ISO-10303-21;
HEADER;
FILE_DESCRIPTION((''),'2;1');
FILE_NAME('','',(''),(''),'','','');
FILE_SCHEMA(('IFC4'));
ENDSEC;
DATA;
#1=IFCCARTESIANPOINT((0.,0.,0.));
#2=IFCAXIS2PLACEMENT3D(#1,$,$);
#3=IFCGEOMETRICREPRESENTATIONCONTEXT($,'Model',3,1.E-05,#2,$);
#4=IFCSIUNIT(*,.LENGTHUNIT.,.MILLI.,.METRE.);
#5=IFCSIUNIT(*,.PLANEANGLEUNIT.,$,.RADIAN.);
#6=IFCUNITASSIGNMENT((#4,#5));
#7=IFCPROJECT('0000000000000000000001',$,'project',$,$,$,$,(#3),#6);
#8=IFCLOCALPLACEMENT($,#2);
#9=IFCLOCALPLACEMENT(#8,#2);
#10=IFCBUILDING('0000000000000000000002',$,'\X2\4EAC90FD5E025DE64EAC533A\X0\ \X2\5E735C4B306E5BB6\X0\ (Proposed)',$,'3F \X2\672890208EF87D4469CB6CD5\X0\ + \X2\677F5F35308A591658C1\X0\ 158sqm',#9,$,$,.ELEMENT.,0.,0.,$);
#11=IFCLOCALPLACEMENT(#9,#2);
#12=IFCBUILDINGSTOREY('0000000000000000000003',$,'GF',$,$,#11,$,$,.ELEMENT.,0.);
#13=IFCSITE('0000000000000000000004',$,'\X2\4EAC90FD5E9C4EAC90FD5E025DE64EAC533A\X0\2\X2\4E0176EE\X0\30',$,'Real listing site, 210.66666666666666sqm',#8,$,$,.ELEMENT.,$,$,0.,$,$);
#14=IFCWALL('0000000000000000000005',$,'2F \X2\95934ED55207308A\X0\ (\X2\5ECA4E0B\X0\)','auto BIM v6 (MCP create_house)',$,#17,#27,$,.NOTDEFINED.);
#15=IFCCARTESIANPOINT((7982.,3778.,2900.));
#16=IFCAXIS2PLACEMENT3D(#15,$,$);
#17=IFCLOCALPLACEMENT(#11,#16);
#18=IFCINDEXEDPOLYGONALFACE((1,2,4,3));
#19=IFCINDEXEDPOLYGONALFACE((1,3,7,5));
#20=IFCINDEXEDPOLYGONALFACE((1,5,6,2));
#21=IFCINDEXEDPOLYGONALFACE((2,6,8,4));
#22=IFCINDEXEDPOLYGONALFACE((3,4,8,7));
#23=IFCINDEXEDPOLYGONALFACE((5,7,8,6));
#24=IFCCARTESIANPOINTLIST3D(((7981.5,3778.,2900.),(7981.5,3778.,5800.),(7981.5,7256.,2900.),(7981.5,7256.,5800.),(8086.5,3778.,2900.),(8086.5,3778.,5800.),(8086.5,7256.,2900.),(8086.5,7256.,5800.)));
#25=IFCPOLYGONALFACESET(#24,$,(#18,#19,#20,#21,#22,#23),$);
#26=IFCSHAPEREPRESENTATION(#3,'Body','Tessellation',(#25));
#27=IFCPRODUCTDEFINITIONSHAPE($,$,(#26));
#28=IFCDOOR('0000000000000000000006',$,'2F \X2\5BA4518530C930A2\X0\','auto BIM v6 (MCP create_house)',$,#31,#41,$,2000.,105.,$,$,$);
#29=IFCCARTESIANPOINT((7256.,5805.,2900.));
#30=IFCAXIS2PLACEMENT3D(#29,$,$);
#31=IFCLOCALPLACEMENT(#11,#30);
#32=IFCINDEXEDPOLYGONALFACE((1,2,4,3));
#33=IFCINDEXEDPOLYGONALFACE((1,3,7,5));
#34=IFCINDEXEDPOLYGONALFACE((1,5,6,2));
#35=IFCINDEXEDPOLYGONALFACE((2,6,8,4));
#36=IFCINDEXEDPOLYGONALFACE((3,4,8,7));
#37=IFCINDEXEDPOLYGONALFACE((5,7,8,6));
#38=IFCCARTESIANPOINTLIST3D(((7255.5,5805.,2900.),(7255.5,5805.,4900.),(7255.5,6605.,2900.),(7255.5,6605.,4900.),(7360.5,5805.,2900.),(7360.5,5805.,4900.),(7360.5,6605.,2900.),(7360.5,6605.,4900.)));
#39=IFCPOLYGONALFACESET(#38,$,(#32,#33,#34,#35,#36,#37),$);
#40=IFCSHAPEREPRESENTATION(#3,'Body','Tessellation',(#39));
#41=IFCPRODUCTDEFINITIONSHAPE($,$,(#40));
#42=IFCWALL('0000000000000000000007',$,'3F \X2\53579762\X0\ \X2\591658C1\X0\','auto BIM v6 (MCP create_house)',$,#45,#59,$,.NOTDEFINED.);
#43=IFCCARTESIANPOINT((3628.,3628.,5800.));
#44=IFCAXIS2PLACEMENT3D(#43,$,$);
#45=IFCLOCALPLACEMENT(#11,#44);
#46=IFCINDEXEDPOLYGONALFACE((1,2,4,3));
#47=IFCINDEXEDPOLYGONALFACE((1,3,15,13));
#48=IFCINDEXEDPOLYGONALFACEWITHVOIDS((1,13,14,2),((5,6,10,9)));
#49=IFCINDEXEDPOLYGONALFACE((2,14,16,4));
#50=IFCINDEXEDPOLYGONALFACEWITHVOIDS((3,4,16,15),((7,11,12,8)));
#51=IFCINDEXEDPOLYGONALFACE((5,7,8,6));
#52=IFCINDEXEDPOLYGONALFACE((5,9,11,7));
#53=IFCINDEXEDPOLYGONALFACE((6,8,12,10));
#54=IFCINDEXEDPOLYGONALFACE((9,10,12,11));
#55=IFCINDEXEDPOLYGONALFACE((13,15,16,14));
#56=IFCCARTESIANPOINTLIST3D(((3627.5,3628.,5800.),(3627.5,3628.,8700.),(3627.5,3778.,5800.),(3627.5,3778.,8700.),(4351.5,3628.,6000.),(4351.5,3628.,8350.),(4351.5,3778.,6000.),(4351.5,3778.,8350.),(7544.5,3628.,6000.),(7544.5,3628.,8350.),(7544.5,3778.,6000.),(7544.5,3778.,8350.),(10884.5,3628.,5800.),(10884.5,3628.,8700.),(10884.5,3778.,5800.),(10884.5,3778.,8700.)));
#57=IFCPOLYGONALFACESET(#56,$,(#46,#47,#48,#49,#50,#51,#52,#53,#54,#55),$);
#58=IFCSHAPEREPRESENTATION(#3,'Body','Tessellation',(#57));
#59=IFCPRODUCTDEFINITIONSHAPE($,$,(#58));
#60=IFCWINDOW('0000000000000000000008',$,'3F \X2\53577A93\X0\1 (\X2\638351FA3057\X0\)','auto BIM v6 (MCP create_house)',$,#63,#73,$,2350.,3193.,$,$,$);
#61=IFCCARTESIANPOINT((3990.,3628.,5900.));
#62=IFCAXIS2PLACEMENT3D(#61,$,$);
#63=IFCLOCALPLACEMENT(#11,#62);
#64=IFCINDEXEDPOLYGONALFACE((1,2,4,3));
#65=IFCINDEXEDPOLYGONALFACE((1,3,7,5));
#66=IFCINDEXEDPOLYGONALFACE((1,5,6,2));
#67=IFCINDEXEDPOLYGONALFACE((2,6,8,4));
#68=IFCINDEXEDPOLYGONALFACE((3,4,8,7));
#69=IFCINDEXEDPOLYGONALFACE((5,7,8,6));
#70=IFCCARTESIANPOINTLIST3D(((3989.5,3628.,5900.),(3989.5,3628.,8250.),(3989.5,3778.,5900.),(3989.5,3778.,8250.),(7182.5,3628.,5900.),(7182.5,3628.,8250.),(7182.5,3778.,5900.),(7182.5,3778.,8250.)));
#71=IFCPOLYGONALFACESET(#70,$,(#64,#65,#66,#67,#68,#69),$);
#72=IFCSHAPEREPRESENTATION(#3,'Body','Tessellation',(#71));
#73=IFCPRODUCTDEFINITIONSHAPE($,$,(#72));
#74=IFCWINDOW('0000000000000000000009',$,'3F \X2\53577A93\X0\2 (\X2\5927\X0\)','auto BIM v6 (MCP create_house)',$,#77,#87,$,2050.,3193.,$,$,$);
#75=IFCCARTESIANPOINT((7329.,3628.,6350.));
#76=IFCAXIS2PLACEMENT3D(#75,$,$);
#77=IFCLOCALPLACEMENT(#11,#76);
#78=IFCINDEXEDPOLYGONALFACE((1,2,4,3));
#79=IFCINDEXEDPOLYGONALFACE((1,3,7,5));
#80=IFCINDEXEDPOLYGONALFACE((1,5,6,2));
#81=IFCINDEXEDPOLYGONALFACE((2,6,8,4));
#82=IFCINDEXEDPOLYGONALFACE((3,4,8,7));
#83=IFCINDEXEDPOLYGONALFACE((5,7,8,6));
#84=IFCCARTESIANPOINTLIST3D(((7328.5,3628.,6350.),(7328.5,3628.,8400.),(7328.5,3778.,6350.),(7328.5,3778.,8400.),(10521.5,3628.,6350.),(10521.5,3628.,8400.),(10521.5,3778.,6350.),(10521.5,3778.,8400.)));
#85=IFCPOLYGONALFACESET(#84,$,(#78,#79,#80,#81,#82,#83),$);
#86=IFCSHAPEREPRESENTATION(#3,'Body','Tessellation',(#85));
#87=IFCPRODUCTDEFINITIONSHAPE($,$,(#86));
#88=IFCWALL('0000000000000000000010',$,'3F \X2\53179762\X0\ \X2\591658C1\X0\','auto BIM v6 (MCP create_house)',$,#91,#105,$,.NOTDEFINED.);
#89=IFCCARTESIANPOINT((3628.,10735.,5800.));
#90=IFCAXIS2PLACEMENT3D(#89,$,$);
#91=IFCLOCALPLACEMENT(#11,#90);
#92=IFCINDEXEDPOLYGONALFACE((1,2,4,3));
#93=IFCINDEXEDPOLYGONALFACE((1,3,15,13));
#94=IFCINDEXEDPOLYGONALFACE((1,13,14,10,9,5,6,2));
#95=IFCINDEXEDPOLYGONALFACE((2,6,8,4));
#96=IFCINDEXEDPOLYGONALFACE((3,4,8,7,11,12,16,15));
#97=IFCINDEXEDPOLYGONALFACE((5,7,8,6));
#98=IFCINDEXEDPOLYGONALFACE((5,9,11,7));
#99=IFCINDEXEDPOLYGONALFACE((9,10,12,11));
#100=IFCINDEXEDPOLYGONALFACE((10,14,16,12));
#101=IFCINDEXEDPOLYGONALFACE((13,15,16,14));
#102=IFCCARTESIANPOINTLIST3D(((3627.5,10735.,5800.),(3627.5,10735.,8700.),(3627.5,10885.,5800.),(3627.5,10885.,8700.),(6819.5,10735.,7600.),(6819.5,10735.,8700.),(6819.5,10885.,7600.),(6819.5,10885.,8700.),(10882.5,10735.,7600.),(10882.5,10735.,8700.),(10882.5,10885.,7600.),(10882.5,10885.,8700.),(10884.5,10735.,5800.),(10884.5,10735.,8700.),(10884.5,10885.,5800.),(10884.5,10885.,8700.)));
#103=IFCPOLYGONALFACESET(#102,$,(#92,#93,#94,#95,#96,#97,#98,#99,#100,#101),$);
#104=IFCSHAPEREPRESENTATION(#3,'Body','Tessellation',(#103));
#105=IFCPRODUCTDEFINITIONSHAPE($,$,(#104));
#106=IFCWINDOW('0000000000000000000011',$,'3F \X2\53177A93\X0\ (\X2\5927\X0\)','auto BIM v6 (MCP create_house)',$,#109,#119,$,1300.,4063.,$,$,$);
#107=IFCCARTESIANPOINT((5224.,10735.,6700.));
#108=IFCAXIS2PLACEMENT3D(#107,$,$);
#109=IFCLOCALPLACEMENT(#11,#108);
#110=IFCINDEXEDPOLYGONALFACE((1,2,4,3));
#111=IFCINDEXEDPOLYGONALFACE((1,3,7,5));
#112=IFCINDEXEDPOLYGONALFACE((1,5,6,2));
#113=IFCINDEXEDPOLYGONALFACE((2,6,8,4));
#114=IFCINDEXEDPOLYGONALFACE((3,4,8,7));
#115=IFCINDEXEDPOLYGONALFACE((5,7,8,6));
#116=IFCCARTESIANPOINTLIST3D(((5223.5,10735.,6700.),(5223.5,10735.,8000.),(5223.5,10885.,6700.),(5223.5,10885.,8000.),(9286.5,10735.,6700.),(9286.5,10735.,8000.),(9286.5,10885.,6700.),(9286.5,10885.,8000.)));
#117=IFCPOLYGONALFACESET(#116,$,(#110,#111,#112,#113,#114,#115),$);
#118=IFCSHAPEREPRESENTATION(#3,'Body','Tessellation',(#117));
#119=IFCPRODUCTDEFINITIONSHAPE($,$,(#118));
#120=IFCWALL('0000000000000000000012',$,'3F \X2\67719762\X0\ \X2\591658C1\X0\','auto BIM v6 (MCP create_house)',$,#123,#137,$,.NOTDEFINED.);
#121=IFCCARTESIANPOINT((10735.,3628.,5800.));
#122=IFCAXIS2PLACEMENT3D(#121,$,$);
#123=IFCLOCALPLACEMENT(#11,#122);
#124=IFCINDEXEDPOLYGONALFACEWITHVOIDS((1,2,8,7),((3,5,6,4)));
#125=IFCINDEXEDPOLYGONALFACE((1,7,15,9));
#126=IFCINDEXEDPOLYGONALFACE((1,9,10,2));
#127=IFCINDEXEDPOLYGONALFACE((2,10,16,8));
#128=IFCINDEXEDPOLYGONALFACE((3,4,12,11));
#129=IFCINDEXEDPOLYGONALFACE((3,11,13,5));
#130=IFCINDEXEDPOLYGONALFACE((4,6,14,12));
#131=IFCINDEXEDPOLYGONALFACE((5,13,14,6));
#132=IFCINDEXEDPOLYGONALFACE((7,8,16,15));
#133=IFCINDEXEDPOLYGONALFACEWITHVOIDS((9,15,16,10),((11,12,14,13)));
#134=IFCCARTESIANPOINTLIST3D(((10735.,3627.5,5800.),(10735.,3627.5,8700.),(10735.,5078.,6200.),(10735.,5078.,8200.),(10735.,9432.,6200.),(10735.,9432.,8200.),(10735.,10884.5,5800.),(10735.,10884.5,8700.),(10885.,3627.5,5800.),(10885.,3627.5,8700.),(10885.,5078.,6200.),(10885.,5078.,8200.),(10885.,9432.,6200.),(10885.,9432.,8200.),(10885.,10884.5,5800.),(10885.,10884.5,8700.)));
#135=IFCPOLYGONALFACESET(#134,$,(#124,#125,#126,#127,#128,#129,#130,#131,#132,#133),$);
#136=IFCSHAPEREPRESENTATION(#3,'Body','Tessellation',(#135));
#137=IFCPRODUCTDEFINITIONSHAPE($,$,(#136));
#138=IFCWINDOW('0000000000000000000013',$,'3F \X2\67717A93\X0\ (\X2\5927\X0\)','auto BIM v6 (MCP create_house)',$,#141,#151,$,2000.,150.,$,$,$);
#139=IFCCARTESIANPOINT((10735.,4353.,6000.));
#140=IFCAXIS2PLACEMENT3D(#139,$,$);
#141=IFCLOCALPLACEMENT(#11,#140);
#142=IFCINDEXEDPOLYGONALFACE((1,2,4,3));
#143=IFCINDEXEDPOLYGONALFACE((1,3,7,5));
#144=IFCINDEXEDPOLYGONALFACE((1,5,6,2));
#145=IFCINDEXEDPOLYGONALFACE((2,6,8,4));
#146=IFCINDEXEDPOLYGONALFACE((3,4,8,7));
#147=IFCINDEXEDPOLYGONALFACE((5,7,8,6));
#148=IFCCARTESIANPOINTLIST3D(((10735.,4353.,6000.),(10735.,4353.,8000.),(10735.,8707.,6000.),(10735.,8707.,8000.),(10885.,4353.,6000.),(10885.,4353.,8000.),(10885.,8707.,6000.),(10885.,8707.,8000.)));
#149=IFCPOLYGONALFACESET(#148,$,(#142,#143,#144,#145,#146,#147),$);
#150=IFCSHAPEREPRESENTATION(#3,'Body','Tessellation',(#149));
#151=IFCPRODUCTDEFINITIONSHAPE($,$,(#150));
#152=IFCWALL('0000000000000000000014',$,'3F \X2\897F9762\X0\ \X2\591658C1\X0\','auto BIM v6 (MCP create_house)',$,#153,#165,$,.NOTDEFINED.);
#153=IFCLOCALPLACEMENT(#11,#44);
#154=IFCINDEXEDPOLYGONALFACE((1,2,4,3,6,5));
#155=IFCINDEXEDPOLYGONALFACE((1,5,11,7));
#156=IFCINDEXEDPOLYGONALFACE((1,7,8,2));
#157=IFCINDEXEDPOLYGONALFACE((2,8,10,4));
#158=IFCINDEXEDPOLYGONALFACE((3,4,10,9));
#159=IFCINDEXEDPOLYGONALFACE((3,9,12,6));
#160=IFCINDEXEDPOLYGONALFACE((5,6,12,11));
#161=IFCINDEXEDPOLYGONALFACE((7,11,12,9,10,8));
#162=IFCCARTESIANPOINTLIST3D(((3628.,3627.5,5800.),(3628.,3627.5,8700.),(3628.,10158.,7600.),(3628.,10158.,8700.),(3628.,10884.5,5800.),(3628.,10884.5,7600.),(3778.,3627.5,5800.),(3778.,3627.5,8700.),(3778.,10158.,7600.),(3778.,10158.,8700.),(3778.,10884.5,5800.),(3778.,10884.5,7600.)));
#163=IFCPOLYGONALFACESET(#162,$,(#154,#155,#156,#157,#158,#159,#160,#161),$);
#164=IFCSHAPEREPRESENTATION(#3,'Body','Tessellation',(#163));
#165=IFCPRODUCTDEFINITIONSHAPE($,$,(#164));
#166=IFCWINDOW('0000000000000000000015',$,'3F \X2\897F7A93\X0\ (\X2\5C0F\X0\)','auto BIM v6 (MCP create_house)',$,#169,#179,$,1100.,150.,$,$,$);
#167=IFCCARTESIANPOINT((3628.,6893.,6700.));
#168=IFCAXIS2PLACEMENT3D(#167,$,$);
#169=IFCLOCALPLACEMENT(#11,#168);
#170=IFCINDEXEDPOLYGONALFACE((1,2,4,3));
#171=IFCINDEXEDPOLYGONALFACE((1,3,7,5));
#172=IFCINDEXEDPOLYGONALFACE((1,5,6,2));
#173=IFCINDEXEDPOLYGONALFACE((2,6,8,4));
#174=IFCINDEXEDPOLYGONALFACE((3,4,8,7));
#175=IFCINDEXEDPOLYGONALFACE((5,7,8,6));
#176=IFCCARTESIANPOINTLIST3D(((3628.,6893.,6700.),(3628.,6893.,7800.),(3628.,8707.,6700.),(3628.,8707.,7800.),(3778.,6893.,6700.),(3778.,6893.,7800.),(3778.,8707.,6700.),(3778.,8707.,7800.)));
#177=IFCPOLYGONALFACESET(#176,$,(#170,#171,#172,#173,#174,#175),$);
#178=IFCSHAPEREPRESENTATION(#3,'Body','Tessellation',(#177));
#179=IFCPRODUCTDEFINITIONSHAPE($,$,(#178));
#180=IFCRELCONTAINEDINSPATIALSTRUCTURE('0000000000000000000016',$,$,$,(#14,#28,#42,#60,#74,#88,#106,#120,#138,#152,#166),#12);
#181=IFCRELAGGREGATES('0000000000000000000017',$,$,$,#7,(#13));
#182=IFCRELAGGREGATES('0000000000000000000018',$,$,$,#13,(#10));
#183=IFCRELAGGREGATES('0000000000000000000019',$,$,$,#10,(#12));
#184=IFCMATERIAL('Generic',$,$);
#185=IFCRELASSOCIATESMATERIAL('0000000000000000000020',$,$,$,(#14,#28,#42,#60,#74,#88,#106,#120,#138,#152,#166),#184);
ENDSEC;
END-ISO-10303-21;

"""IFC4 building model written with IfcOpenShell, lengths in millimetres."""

from ifc_helpers import new_model, si_unit, frame, frame_2d, origin, place, context, project, spatial, rectangle, extrude, material, element, fill, save


model = new_model("IFC4")

# Units and contexts
model_context = context("Model", 3, precision=1e-05, world=origin())
ifc_project = project(units=[si_unit("LENGTHUNIT", "METRE", prefix="MILLI"), si_unit("PLANEANGLEUNIT", "RADIAN")], contexts=[model_context])

# Site, building, storey
site_placement = place(None, origin())
site = spatial("IfcSite", under=ifc_project, at=site_placement, Name="京都府京都市左京区2丁目30", ObjectType="Real listing site, 210.66666666666666sqm", CompositionType="ELEMENT", RefElevation=0.0)
building_placement = place(site_placement, origin())
building = spatial("IfcBuilding", under=site, at=building_placement, Name="京都市左京区 平屋の家 (Proposed)", ObjectType="3F 木造軸組構法 + 板張り外壁 158sqm", CompositionType="ELEMENT", ElevationOfRefHeight=0.0, ElevationOfTerrain=0.0)
storey_placement = place(building_placement, origin())
storey = spatial("IfcBuildingStorey", under=building, at=storey_placement, Name="GF", CompositionType="ELEMENT", Elevation=0.0)

# Shared definitions
ifc_material = material(Name="Generic")

# Wall
wall_1_placement = place(storey_placement, frame((7982.0, 3778.0, 2900.0)))
element("IfcWall", 1, at=wall_1_placement, inside=storey, material=ifc_material, Name="2F 間仕切り (廊下)", Description="auto BIM v6 (MCP create_house)", PredefinedType="NOTDEFINED", context=model_context, shape_type="SweptSolid", body=[
    extrude(rectangle(XDim=105.0, YDim=3478.0, at=frame_2d((52.0, 1739.0))), frame((7982.0, 3778.0, 2900.0)), (0.0, 0.0, 1.0), 2900.0),
])

# Door
door_1_placement = place(storey_placement, frame((7256.0, 5805.0, 2900.0)))
element("IfcDoor", 2, at=door_1_placement, inside=storey, material=ifc_material, Name="2F 室内ドア", Description="auto BIM v6 (MCP create_house)", OverallHeight=2000.0, OverallWidth=105.0, context=model_context, shape_type="SweptSolid", body=[
    extrude(rectangle(XDim=105.0, YDim=800.0, at=frame_2d((52.0, 400.0))), frame((7256.0, 5805.0, 2900.0)), (0.0, 0.0, 1.0), 2000.0),
])

# Wall, openings, windows
wall_2_placement = place(storey_placement, frame((3628.0, 3628.0, 5800.0)))
wall_2 = element("IfcWall", 3, at=wall_2_placement, inside=storey, material=ifc_material, Name="3F 南面 外壁", Description="auto BIM v6 (MCP create_house)", PredefinedType="NOTDEFINED", context=model_context, shape_type="SweptSolid", body=[
    extrude(rectangle(XDim=7257.0, YDim=150.0, at=frame_2d((3628.0, 75.0))), frame((3628.0, 3628.0, 5800.0)), (0.0, 0.0, 1.0), 2900.0),
])
opening_1_placement = place(storey_placement, frame((3990.0, 3628.0, 5900.0)))
opening_1 = element("IfcOpeningElement", 4, at=opening_1_placement, cuts=wall_2, PredefinedType="NOTDEFINED", context=model_context, shape_type="SweptSolid", body=[
    extrude(rectangle(XDim=3193.0, YDim=150.0, at=frame_2d((1596.0, 75.0))), frame((3990.0, 3628.0, 5900.0)), (0.0, 0.0, 1.0), 2350.0),
])
opening_2_placement = place(storey_placement, frame((7329.0, 3628.0, 6350.0)))
opening_2 = element("IfcOpeningElement", 5, at=opening_2_placement, cuts=wall_2, PredefinedType="NOTDEFINED", context=model_context, shape_type="SweptSolid", body=[
    extrude(rectangle(XDim=3193.0, YDim=150.0, at=frame_2d((1596.0, 75.0))), frame((7329.0, 3628.0, 6350.0)), (0.0, 0.0, 1.0), 2050.0),
])
window_1_placement = place(storey_placement, frame((3990.0, 3628.0, 5900.0)))
window_1 = element("IfcWindow", 6, at=window_1_placement, inside=storey, material=ifc_material, Name="3F 南窓1 (掃出し)", Description="auto BIM v6 (MCP create_house)", OverallHeight=2350.0, OverallWidth=3193.0, context=model_context, shape_type="SweptSolid", body=[
    extrude(rectangle(XDim=3193.0, YDim=150.0, at=frame_2d((1596.0, 75.0))), frame((3990.0, 3628.0, 5900.0)), (0.0, 0.0, 1.0), 2350.0),
])
fill(opening_1, window_1)
window_2_placement = place(storey_placement, frame((7329.0, 3628.0, 6350.0)))
window_2 = element("IfcWindow", 7, at=window_2_placement, inside=storey, material=ifc_material, Name="3F 南窓2 (大)", Description="auto BIM v6 (MCP create_house)", OverallHeight=2050.0, OverallWidth=3193.0, context=model_context, shape_type="SweptSolid", body=[
    extrude(rectangle(XDim=3193.0, YDim=150.0, at=frame_2d((1596.0, 75.0))), frame((7329.0, 3628.0, 6350.0)), (0.0, 0.0, 1.0), 2050.0),
])
fill(opening_2, window_2)

# Walls, openings, windows
wall_3_placement = place(storey_placement, frame((3628.0, 10735.0, 5800.0)))
wall_3 = element("IfcWall", 8, at=wall_3_placement, inside=storey, material=ifc_material, Name="3F 北面 外壁", Description="auto BIM v6 (MCP create_house)", PredefinedType="NOTDEFINED", context=model_context, shape_type="SweptSolid", body=[
    extrude(rectangle(XDim=7257.0, YDim=150.0, at=frame_2d((3628.0, 75.0))), frame((3628.0, 10735.0, 5800.0)), (0.0, 0.0, 1.0), 2900.0),
])
opening_3_placement = place(storey_placement, frame((5224.0, 10735.0, 6700.0)))
opening_3 = element("IfcOpeningElement", 9, at=opening_3_placement, cuts=wall_3, PredefinedType="NOTDEFINED", context=model_context, shape_type="SweptSolid", body=[
    extrude(rectangle(XDim=4063.0, YDim=150.0, at=frame_2d((2031.0, 75.0))), frame((5224.0, 10735.0, 6700.0)), (0.0, 0.0, 1.0), 1300.0),
])
window_3_placement = place(storey_placement, frame((5224.0, 10735.0, 6700.0)))
window_3 = element("IfcWindow", 10, at=window_3_placement, inside=storey, material=ifc_material, Name="3F 北窓 (大)", Description="auto BIM v6 (MCP create_house)", OverallHeight=1300.0, OverallWidth=4063.0, context=model_context, shape_type="SweptSolid", body=[
    extrude(rectangle(XDim=4063.0, YDim=150.0, at=frame_2d((2031.0, 75.0))), frame((5224.0, 10735.0, 6700.0)), (0.0, 0.0, 1.0), 1300.0),
])
fill(opening_3, window_3)
wall_4_placement = place(storey_placement, frame((10735.0, 3628.0, 5800.0)))
wall_4 = element("IfcWall", 11, at=wall_4_placement, inside=storey, material=ifc_material, Name="3F 東面 外壁", Description="auto BIM v6 (MCP create_house)", PredefinedType="NOTDEFINED", context=model_context, shape_type="SweptSolid", body=[
    extrude(rectangle(XDim=150.0, YDim=7257.0, at=frame_2d((75.0, 3628.0))), frame((10735.0, 3628.0, 5800.0)), (0.0, 0.0, 1.0), 2900.0),
])
opening_4_placement = place(storey_placement, frame((10735.0, 4353.0, 6000.0)))
opening_4 = element("IfcOpeningElement", 12, at=opening_4_placement, cuts=wall_4, PredefinedType="NOTDEFINED", context=model_context, shape_type="SweptSolid", body=[
    extrude(rectangle(XDim=150.0, YDim=4354.0, at=frame_2d((75.0, 2177.0))), frame((10735.0, 4353.0, 6000.0)), (0.0, 0.0, 1.0), 2000.0),
])
window_4_placement = place(storey_placement, frame((10735.0, 4353.0, 6000.0)))
window_4 = element("IfcWindow", 13, at=window_4_placement, inside=storey, material=ifc_material, Name="3F 東窓 (大)", Description="auto BIM v6 (MCP create_house)", OverallHeight=2000.0, OverallWidth=150.0, context=model_context, shape_type="SweptSolid", body=[
    extrude(rectangle(XDim=150.0, YDim=4354.0, at=frame_2d((75.0, 2177.0))), frame((10735.0, 4353.0, 6000.0)), (0.0, 0.0, 1.0), 2000.0),
])
fill(opening_4, window_4)
wall_5_placement = place(storey_placement, frame((3628.0, 3628.0, 5800.0)))
wall_5 = element("IfcWall", 14, at=wall_5_placement, inside=storey, material=ifc_material, Name="3F 西面 外壁", Description="auto BIM v6 (MCP create_house)", PredefinedType="NOTDEFINED", context=model_context, shape_type="SweptSolid", body=[
    extrude(rectangle(XDim=150.0, YDim=7257.0, at=frame_2d((75.0, 3628.0))), frame((3628.0, 3628.0, 5800.0)), (0.0, 0.0, 1.0), 2900.0),
])
opening_5_placement = place(storey_placement, frame((3628.0, 6893.0, 6700.0)))
opening_5 = element("IfcOpeningElement", 15, at=opening_5_placement, cuts=wall_5, PredefinedType="NOTDEFINED", context=model_context, shape_type="SweptSolid", body=[
    extrude(rectangle(XDim=150.0, YDim=1814.0, at=frame_2d((75.0, 907.0))), frame((3628.0, 6893.0, 6700.0)), (0.0, 0.0, 1.0), 1100.0),
])
window_5_placement = place(storey_placement, frame((3628.0, 6893.0, 6700.0)))
window_5 = element("IfcWindow", 16, at=window_5_placement, inside=storey, material=ifc_material, Name="3F 西窓 (小)", Description="auto BIM v6 (MCP create_house)", OverallHeight=1100.0, OverallWidth=150.0, context=model_context, shape_type="SweptSolid", body=[
    extrude(rectangle(XDim=150.0, YDim=1814.0, at=frame_2d((75.0, 907.0))), frame((3628.0, 6893.0, 6700.0)), (0.0, 0.0, 1.0), 1100.0),
])
fill(opening_5, window_5)

save(model, "model.ifc")
